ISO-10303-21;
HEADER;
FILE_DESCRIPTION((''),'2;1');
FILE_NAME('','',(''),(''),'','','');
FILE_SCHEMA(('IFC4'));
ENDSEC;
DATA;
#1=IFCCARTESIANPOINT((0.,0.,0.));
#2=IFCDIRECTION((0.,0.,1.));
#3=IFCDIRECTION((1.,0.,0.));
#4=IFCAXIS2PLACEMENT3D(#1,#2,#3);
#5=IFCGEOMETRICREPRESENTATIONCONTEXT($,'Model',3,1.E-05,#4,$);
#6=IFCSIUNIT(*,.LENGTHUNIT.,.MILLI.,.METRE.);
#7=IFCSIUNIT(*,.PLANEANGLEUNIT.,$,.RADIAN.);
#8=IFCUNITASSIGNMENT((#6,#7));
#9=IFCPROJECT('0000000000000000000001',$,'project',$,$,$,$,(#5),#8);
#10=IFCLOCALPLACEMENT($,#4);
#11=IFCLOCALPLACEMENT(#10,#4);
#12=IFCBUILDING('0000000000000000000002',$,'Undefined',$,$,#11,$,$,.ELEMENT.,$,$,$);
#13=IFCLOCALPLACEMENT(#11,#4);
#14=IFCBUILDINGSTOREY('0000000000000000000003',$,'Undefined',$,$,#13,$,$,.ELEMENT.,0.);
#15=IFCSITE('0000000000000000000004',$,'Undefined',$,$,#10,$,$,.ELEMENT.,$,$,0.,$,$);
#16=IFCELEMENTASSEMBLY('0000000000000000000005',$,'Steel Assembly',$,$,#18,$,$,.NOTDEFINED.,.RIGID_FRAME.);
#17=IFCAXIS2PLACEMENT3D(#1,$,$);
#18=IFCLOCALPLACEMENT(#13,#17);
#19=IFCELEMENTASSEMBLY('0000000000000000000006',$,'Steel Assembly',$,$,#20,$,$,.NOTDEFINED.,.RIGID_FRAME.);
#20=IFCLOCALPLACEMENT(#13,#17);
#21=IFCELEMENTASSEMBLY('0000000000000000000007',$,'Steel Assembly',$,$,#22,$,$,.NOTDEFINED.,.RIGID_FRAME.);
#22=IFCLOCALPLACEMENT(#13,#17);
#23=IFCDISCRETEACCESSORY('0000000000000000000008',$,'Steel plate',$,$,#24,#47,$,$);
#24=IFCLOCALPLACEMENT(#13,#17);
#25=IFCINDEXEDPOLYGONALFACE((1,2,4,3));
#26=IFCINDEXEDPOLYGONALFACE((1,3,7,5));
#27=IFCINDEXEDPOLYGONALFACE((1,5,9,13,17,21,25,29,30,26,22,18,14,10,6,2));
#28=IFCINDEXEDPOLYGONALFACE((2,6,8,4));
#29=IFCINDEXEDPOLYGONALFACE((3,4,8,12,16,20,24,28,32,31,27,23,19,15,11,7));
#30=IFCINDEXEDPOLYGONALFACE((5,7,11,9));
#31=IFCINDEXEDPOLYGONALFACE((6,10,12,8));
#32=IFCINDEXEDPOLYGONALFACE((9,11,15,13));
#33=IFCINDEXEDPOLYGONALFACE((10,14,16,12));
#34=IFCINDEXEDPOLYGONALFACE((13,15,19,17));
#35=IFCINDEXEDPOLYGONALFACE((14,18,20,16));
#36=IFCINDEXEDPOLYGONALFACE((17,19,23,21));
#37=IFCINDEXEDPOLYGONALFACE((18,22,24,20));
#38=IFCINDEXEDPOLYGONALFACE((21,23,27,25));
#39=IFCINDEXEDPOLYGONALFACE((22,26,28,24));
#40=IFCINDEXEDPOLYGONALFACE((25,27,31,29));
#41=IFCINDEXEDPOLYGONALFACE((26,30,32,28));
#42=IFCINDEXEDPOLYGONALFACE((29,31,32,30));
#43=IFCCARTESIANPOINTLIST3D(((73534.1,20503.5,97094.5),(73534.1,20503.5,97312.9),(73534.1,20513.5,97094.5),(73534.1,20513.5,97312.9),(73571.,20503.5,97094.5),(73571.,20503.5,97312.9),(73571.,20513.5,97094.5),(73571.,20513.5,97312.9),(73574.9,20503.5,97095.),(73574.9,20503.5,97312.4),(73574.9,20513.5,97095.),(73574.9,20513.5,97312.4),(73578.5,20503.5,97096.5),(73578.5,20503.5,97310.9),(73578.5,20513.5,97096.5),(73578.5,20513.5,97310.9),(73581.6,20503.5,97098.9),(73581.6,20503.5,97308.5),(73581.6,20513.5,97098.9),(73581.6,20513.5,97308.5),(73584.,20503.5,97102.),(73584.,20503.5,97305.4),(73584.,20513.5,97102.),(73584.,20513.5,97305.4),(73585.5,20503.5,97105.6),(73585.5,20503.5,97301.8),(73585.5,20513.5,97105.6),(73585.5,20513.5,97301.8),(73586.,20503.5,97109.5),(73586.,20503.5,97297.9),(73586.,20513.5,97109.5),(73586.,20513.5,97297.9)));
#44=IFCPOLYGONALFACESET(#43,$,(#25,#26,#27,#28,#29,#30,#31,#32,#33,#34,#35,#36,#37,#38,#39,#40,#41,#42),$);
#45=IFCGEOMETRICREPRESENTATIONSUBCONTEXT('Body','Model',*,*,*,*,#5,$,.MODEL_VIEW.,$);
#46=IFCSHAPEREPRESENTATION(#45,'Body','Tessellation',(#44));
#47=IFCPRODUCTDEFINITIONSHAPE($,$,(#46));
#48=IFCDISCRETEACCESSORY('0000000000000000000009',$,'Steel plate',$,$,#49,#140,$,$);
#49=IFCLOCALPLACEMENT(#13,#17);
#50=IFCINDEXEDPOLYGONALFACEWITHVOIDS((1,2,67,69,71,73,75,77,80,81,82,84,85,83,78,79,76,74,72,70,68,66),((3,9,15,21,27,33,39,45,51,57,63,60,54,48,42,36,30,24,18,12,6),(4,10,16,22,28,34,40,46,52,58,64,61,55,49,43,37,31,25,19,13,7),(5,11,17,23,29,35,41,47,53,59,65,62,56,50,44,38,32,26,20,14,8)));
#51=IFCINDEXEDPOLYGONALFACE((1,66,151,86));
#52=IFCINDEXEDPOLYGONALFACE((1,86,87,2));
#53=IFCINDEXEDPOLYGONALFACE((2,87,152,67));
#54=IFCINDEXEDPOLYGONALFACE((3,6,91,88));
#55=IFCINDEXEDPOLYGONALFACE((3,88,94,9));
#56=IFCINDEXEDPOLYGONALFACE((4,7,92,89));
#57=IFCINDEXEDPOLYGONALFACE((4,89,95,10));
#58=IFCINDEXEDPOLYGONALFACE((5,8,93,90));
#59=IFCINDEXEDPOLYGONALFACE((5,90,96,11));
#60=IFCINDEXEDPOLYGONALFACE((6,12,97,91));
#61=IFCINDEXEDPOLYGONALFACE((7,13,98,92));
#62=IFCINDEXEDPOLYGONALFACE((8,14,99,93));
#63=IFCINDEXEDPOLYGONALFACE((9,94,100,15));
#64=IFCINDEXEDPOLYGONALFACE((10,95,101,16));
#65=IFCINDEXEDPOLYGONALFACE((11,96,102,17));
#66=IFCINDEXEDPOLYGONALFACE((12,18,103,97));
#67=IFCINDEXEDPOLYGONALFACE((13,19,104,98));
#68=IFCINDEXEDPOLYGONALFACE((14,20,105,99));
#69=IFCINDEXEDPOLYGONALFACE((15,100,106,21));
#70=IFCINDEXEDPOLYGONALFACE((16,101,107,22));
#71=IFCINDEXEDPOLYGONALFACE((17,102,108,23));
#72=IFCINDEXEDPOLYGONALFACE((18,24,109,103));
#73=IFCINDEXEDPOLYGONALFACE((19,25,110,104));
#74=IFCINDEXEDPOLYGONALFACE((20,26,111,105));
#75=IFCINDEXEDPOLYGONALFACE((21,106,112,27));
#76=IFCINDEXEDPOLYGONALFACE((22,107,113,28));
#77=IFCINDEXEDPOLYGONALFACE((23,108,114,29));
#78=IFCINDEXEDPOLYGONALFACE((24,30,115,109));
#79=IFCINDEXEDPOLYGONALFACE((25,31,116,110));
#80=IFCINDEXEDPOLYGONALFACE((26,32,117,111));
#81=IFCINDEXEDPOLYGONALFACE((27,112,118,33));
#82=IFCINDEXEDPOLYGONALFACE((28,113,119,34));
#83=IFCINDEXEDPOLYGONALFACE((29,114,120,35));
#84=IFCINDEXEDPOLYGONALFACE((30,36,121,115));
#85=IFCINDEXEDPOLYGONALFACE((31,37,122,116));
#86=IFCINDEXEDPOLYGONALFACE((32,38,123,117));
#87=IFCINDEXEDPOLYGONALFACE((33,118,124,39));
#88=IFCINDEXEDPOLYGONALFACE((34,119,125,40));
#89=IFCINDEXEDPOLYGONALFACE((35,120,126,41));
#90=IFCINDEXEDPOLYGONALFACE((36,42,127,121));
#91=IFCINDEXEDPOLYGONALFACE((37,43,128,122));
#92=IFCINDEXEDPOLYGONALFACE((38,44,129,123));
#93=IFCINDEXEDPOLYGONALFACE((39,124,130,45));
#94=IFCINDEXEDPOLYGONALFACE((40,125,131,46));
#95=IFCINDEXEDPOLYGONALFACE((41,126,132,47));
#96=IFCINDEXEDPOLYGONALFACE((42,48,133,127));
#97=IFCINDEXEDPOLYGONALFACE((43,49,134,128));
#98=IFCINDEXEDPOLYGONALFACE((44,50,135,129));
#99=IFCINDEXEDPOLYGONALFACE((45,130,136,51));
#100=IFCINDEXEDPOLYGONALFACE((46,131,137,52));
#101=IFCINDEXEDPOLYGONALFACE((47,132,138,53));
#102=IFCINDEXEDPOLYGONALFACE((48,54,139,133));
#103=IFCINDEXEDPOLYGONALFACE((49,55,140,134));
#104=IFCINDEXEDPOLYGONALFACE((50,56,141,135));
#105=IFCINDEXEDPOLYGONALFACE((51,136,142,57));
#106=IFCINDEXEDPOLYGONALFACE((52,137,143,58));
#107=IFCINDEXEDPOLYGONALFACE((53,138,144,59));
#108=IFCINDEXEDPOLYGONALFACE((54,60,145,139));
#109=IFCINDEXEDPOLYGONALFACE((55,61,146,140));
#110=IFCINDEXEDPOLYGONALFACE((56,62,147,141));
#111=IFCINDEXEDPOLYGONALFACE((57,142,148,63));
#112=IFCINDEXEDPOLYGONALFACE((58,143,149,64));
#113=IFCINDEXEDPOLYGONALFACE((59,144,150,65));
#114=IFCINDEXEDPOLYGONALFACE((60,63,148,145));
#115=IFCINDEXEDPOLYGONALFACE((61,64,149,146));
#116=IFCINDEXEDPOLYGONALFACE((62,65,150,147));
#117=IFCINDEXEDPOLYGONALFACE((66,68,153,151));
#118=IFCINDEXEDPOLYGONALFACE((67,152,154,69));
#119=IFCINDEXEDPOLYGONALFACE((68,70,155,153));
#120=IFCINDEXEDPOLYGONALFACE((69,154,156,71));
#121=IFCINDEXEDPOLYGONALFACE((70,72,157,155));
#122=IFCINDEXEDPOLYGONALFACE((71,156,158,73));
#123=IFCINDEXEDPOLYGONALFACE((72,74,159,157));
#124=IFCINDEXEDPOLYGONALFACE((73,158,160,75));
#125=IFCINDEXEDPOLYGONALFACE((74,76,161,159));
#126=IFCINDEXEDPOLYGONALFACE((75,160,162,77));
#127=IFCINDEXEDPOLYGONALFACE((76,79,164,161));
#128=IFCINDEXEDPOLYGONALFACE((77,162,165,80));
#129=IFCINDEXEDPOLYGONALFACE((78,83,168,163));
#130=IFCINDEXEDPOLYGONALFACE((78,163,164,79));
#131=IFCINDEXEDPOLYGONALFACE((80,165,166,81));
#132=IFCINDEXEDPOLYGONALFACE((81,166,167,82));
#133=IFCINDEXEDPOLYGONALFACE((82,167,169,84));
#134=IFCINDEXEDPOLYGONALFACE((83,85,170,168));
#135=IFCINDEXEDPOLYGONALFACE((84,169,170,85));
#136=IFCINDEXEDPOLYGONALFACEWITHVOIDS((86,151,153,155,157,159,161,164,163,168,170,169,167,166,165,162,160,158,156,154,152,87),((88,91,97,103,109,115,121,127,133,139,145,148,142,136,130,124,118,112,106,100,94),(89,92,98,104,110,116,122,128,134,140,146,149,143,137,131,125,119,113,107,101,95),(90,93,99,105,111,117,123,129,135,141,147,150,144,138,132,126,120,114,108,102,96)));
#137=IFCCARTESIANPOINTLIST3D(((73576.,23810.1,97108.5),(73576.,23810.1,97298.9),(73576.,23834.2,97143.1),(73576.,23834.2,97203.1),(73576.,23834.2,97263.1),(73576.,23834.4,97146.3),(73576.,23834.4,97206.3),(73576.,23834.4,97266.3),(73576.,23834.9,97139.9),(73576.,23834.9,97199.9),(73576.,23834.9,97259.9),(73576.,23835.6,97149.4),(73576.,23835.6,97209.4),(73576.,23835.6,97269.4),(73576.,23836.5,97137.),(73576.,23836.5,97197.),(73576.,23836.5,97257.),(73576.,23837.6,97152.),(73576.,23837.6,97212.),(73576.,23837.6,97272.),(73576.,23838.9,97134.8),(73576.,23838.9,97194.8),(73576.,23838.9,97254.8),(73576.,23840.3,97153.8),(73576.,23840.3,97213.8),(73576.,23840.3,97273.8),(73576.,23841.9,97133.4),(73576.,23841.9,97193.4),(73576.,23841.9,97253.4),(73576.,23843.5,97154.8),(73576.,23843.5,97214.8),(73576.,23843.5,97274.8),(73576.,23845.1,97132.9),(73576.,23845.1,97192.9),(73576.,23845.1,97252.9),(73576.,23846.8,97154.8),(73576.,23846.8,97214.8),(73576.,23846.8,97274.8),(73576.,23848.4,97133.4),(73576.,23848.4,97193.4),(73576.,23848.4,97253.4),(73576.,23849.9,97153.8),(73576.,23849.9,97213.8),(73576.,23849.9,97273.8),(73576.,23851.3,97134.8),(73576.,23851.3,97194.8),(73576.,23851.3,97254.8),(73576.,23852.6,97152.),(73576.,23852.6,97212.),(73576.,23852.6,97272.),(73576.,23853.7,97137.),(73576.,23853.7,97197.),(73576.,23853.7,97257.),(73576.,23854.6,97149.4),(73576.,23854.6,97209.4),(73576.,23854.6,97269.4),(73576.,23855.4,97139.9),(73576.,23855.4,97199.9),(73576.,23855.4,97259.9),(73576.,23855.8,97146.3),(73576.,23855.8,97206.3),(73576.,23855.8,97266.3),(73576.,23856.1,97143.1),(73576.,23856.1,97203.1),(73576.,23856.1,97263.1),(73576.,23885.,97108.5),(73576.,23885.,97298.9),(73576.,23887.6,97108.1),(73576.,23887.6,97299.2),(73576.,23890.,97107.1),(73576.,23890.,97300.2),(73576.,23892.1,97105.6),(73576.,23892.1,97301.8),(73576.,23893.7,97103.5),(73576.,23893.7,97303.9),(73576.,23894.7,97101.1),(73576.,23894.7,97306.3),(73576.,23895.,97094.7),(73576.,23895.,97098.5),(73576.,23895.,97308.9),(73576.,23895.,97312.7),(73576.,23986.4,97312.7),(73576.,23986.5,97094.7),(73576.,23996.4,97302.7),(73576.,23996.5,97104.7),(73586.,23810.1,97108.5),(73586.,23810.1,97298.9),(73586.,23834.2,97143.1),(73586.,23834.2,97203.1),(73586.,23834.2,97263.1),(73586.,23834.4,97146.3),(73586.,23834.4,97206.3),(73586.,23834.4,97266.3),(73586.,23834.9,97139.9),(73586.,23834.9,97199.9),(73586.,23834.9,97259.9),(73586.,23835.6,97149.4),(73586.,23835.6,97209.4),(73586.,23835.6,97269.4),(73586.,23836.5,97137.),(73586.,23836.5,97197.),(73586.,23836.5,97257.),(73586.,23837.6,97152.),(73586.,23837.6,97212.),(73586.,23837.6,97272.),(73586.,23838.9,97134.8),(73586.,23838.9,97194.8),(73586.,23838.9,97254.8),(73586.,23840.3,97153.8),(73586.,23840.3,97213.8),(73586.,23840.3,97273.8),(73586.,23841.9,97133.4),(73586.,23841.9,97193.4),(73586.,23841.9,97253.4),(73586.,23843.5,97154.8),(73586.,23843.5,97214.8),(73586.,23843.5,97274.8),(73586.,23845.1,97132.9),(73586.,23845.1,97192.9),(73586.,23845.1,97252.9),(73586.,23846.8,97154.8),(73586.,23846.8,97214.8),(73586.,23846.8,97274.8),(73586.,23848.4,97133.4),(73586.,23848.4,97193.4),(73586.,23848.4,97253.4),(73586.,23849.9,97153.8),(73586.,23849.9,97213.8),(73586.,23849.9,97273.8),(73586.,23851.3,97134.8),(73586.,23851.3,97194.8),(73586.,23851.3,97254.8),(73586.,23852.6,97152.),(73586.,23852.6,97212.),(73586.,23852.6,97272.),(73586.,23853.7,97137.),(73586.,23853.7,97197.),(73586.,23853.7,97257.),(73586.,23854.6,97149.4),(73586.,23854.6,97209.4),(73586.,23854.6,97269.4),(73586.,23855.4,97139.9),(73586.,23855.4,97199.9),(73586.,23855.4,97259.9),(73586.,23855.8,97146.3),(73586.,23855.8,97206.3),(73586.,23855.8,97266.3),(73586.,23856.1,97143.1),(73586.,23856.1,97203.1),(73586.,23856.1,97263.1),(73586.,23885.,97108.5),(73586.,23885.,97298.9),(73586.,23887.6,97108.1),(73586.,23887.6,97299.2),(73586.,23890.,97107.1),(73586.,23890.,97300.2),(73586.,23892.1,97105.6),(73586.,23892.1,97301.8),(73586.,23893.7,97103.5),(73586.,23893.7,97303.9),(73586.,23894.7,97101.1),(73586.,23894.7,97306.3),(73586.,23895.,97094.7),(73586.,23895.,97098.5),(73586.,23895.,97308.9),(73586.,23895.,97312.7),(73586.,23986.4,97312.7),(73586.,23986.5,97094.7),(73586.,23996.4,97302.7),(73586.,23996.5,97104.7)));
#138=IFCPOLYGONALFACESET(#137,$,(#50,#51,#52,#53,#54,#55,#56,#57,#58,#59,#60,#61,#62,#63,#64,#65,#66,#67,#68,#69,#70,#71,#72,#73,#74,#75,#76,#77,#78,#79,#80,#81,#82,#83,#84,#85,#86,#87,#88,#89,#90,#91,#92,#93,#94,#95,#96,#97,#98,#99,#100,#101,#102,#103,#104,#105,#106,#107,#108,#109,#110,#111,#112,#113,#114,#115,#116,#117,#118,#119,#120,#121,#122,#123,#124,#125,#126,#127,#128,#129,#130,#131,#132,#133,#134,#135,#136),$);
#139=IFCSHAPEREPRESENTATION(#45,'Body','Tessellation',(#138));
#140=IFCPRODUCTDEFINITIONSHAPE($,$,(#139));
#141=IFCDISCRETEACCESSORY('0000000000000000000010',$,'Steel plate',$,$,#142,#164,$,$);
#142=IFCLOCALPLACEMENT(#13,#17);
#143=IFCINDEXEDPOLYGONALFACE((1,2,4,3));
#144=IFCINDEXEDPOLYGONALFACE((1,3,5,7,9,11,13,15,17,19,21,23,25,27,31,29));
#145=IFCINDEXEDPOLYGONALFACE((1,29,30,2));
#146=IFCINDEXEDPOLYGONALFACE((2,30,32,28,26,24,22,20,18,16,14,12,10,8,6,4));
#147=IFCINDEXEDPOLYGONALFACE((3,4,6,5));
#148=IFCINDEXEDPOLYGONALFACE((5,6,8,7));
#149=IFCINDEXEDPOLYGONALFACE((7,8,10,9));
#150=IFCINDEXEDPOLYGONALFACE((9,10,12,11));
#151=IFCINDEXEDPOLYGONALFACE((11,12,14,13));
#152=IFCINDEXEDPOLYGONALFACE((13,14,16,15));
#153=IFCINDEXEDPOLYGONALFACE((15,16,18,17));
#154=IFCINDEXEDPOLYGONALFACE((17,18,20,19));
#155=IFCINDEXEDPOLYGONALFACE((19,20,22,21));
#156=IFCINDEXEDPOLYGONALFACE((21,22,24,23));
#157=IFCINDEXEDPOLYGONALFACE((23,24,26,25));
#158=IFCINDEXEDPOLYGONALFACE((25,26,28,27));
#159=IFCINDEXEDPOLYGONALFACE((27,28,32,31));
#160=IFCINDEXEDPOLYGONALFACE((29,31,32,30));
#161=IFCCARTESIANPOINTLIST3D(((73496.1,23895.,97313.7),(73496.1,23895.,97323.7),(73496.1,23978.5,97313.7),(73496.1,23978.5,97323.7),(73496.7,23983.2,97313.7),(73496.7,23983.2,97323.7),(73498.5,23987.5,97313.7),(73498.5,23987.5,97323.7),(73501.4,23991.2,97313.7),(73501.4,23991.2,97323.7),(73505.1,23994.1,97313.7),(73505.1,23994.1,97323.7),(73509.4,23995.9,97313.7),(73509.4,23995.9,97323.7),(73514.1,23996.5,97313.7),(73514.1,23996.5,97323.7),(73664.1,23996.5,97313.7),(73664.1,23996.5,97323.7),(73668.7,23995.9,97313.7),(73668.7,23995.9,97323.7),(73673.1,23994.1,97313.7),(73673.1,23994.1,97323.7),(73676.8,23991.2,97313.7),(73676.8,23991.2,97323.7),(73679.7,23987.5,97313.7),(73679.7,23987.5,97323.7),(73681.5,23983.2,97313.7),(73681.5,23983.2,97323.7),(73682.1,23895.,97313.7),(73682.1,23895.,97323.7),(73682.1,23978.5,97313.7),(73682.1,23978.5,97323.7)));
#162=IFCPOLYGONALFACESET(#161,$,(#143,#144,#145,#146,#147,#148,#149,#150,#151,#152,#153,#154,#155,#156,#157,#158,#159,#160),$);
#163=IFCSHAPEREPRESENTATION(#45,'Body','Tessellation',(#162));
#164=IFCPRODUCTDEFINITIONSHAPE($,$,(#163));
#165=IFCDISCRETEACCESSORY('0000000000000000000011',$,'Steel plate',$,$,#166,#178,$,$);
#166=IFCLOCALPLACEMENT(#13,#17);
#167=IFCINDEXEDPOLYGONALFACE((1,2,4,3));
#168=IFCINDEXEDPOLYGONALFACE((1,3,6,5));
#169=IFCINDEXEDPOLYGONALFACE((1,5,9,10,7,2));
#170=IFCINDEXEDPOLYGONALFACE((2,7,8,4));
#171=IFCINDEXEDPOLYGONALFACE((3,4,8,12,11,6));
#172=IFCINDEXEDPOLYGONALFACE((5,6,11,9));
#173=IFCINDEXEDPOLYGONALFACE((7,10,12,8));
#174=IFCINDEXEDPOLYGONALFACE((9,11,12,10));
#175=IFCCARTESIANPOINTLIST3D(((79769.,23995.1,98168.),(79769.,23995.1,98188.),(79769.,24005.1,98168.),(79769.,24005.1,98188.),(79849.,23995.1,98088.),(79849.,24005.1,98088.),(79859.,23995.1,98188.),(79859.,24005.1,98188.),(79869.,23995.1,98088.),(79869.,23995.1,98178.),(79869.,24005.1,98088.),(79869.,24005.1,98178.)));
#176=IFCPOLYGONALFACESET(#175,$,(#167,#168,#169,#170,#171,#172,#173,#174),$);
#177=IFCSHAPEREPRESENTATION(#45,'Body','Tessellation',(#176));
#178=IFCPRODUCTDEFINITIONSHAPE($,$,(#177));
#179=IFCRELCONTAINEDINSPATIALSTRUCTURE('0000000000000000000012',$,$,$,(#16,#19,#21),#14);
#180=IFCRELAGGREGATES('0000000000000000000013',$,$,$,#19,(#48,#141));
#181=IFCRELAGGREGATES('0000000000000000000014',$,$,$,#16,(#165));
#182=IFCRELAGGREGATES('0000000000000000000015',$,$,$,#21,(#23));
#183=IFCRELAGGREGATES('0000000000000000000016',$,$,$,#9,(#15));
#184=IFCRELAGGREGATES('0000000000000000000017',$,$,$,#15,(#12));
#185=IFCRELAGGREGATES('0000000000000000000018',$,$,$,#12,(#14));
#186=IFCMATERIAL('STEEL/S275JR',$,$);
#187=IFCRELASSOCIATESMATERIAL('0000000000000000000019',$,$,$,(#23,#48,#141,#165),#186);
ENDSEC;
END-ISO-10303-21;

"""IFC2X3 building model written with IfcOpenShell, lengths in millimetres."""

from ifc_helpers import new_model, si_unit, frame, frame_2d, origin_with_axes, origin_2d_with_axis, place, context, subcontext, project, spatial, polyline, circle_curve, parameter, trimmed, segment, composite_curve, circle, outline, extrude, source, transform, mapped, material, element, aggregate, save


model = new_model("IFC2X3")

# Units and contexts
model_context = context("Model", 3, precision=1e-05, world=origin_with_axes())
body_context = subcontext(model_context, "Body", "Model", "MODEL_VIEW")
ifc_project = project(units=[si_unit("LENGTHUNIT", "METRE", prefix="MILLI"), si_unit("PLANEANGLEUNIT", "RADIAN")], contexts=[model_context])

# Site, building, storey
site_placement = place(None, origin_with_axes())
site = spatial("IfcSite", under=ifc_project, at=site_placement, Name="Undefined", CompositionType="ELEMENT", RefElevation=0.0)
building_placement = place(site_placement, origin_with_axes())
building = spatial("IfcBuilding", under=site, at=building_placement, Name="Undefined", CompositionType="ELEMENT")
storey_placement = place(building_placement, origin_with_axes())
storey = spatial("IfcBuildingStorey", under=building, at=storey_placement, Name="Undefined", CompositionType="ELEMENT", Elevation=0.0)

# Element assembly
assembly_1_placement = place(storey_placement, origin_with_axes())
assembly_1 = element("IfcElementAssembly", 1, at=assembly_1_placement, inside=storey, Name="Steel Assembly", AssemblyPlace="NOTDEFINED", PredefinedType="RIGID_FRAME")

# Element assembly
assembly_2_placement = place(storey_placement, origin_with_axes())
assembly_2 = element("IfcElementAssembly", 2, at=assembly_2_placement, inside=storey, Name="Steel Assembly", AssemblyPlace="NOTDEFINED", PredefinedType="RIGID_FRAME")

# Element assembly, discrete accessory
assembly_3_placement = place(storey_placement, origin_with_axes())
assembly_3 = element("IfcElementAssembly", 3, at=assembly_3_placement, inside=storey, Name="Steel Assembly", AssemblyPlace="NOTDEFINED", PredefinedType="RIGID_FRAME")
ifc_material_1 = material(Name="STEEL/S275JR")
discrete_accessory_1_placement = place(assembly_3_placement, frame((73586.0, 20508.5, 97312.9), z_axis=(0.0, -1.0, 0.0), x_axis=(-1.0, 0.0, 0.0)))
discrete_accessory_1 = element("IfcDiscreteAccessory", 4, at=discrete_accessory_1_placement, material=ifc_material_1, Name="Steel plate", context=body_context, shape_type="SweptSolid", body=[
    extrude(outline(composite_curve([segment(trimmed(circle_curve(frame_2d((15.0, 15.0), x_axis=(-1.0, 0.0)), 15.0), [parameter(0.0)], [parameter(1.570796)], True, "PARAMETER"), True, "CONTINUOUS"), segment(polyline([(15.0, 0.0), (51.9, 0.0), (51.9, 218.4), (15.0, 218.4)]), True, "CONTINUOUS"), segment(trimmed(circle_curve(frame_2d((15.0, 203.4), x_axis=(0.0, 1.0)), 15.0), [parameter(0.0)], [parameter(1.570796)], True, "PARAMETER"), True, "CONTINUOUS"), segment(polyline([(0.0, 203.4), (0.0, 15.0)]), True, "DISCONTINUOUS")], self_intersect=False)), frame((0.0, 0.0, -5.0), z_axis=(0.0, 0.0, 1.0), x_axis=(1.0, 0.0, 0.0)), (0.0, 0.0, 1.0), 10.0),
])

# Discrete accessory, opening
discrete_accessory_2_placement = place(assembly_2_placement, frame((73581.0, 23895.0, 97312.7), z_axis=(-1.0, 0.0, 0.0), x_axis=(0.0, 1.0, 0.0)))
discrete_accessory_2 = element("IfcDiscreteAccessory", 5, at=discrete_accessory_2_placement, material=ifc_material_1, Name="Steel plate", context=body_context, shape_type="SweptSolid", body=[
    extrude(outline(composite_curve([segment(polyline([(0.0, 0.0), (91.4, 0.0), (101.4, 10.0), (101.5, 208.0), (91.5, 218.0), (0.0, 218.0), (0.0, 214.2)]), True, "CONTINUOUS"), segment(trimmed(circle_curve(frame_2d((-10.0, 214.2), x_axis=(1.0, 0.0)), 10.0), [parameter(0.0)], [parameter(4.712389)], False, "PARAMETER"), True, "CONTINUOUS"), segment(polyline([(-10.0, 204.2), (-84.9, 204.2), (-84.9, 13.8), (-10.0, 13.8)]), True, "CONTINUOUS"), segment(trimmed(circle_curve(frame_2d((-10.0, 3.8), x_axis=(0.0, 1.0)), 10.0), [parameter(0.0)], [parameter(4.712389)], False, "PARAMETER"), True, "CONTINUOUS"), segment(polyline([(0.0, 3.8), (0.0, 0.0)]), True, "DISCONTINUOUS")], self_intersect=False)), frame((0.0, 0.0, -5.0), z_axis=(0.0, 0.0, 1.0), x_axis=(1.0, 0.0, 0.0)), (0.0, 0.0, 1.0), 10.0),
])
shared_shape_1 = source(origin_with_axes(), body_context, "Body", "SweptSolid", [
    extrude(circle(Radius=11.0, at=origin_2d_with_axis()), frame((0.0, -0.1, 0.0), z_axis=(0.0, 1.0, 0.0), x_axis=(1.0, 0.0, 0.0)), (0.0, 0.0, 1.0), 10.2),
])
opening_1_placement = place(assembly_2_placement, frame((73586.0, 23845.1, 97263.9), z_axis=(0.0, 1.0, 0.0), x_axis=(0.0, 0.0, -1.0)))
element("IfcOpeningElement", 6, at=opening_1_placement, cuts=discrete_accessory_2, ObjectType="Opening", context=body_context, shape_type="MappedRepresentation", body=[
    mapped(shared_shape_1, transform((0.0, 0.0, 0.0))),
    mapped(shared_shape_1, transform((60.0, 0.0, 0.0))),
    mapped(shared_shape_1, transform((120.0, 0.0, 0.0))),
])

# Discrete accessories
discrete_accessory_3_placement = place(assembly_2_placement, frame((73496.1, 23895.0, 97318.7), z_axis=(0.0, 0.0, 1.0), x_axis=(1.0, 0.0, 0.0)))
discrete_accessory_3 = element("IfcDiscreteAccessory", 7, at=discrete_accessory_3_placement, material=ifc_material_1, Name="Steel plate", context=body_context, shape_type="SweptSolid", body=[
    extrude(outline(composite_curve([segment(polyline([(0.0, 0.0), (186.0, 0.0), (186.0, 83.5)]), True, "CONTINUOUS"), segment(trimmed(circle_curve(frame_2d((168.0, 83.5), x_axis=(1.0, 0.0)), 18.0), [parameter(0.0)], [parameter(1.570796)], True, "PARAMETER"), True, "CONTINUOUS"), segment(polyline([(168.0, 101.5), (18.0, 101.5)]), True, "CONTINUOUS"), segment(trimmed(circle_curve(frame_2d((18.0, 83.5), x_axis=(0.0, 1.0)), 18.0), [parameter(0.0)], [parameter(1.570796)], True, "PARAMETER"), True, "CONTINUOUS"), segment(polyline([(0.0, 83.5), (0.0, 0.0)]), True, "DISCONTINUOUS")], self_intersect=False)), frame((0.0, 0.0, -5.0), z_axis=(0.0, 0.0, 1.0), x_axis=(1.0, 0.0, 0.0)), (0.0, 0.0, 1.0), 10.0),
])
discrete_accessory_4_placement = place(assembly_1_placement, frame((79869.0, 24000.1, 98088.0), z_axis=(0.0, -1.0, 0.0), x_axis=(0.0, 0.0, 1.0)))
discrete_accessory_4 = element("IfcDiscreteAccessory", 8, at=discrete_accessory_4_placement, material=ifc_material_1, Name="Steel plate", context=body_context, shape_type="SweptSolid", body=[
    extrude(outline(polyline([(0.0, 0.0), (90.0, 0.0), (100.0, 10.0), (100.0, 100.0), (80.0, 100.0), (0.0, 20.0), (0.0, 0.0)])), frame((0.0, 0.0, -5.0), z_axis=(0.0, 0.0, 1.0), x_axis=(1.0, 0.0, 0.0)), (0.0, 0.0, 1.0), 10.0),
])
aggregate(assembly_2, [discrete_accessory_2, discrete_accessory_3])
aggregate(assembly_1, [discrete_accessory_4])

aggregate(assembly_3, [discrete_accessory_1])

save(model, "model.ifc")
